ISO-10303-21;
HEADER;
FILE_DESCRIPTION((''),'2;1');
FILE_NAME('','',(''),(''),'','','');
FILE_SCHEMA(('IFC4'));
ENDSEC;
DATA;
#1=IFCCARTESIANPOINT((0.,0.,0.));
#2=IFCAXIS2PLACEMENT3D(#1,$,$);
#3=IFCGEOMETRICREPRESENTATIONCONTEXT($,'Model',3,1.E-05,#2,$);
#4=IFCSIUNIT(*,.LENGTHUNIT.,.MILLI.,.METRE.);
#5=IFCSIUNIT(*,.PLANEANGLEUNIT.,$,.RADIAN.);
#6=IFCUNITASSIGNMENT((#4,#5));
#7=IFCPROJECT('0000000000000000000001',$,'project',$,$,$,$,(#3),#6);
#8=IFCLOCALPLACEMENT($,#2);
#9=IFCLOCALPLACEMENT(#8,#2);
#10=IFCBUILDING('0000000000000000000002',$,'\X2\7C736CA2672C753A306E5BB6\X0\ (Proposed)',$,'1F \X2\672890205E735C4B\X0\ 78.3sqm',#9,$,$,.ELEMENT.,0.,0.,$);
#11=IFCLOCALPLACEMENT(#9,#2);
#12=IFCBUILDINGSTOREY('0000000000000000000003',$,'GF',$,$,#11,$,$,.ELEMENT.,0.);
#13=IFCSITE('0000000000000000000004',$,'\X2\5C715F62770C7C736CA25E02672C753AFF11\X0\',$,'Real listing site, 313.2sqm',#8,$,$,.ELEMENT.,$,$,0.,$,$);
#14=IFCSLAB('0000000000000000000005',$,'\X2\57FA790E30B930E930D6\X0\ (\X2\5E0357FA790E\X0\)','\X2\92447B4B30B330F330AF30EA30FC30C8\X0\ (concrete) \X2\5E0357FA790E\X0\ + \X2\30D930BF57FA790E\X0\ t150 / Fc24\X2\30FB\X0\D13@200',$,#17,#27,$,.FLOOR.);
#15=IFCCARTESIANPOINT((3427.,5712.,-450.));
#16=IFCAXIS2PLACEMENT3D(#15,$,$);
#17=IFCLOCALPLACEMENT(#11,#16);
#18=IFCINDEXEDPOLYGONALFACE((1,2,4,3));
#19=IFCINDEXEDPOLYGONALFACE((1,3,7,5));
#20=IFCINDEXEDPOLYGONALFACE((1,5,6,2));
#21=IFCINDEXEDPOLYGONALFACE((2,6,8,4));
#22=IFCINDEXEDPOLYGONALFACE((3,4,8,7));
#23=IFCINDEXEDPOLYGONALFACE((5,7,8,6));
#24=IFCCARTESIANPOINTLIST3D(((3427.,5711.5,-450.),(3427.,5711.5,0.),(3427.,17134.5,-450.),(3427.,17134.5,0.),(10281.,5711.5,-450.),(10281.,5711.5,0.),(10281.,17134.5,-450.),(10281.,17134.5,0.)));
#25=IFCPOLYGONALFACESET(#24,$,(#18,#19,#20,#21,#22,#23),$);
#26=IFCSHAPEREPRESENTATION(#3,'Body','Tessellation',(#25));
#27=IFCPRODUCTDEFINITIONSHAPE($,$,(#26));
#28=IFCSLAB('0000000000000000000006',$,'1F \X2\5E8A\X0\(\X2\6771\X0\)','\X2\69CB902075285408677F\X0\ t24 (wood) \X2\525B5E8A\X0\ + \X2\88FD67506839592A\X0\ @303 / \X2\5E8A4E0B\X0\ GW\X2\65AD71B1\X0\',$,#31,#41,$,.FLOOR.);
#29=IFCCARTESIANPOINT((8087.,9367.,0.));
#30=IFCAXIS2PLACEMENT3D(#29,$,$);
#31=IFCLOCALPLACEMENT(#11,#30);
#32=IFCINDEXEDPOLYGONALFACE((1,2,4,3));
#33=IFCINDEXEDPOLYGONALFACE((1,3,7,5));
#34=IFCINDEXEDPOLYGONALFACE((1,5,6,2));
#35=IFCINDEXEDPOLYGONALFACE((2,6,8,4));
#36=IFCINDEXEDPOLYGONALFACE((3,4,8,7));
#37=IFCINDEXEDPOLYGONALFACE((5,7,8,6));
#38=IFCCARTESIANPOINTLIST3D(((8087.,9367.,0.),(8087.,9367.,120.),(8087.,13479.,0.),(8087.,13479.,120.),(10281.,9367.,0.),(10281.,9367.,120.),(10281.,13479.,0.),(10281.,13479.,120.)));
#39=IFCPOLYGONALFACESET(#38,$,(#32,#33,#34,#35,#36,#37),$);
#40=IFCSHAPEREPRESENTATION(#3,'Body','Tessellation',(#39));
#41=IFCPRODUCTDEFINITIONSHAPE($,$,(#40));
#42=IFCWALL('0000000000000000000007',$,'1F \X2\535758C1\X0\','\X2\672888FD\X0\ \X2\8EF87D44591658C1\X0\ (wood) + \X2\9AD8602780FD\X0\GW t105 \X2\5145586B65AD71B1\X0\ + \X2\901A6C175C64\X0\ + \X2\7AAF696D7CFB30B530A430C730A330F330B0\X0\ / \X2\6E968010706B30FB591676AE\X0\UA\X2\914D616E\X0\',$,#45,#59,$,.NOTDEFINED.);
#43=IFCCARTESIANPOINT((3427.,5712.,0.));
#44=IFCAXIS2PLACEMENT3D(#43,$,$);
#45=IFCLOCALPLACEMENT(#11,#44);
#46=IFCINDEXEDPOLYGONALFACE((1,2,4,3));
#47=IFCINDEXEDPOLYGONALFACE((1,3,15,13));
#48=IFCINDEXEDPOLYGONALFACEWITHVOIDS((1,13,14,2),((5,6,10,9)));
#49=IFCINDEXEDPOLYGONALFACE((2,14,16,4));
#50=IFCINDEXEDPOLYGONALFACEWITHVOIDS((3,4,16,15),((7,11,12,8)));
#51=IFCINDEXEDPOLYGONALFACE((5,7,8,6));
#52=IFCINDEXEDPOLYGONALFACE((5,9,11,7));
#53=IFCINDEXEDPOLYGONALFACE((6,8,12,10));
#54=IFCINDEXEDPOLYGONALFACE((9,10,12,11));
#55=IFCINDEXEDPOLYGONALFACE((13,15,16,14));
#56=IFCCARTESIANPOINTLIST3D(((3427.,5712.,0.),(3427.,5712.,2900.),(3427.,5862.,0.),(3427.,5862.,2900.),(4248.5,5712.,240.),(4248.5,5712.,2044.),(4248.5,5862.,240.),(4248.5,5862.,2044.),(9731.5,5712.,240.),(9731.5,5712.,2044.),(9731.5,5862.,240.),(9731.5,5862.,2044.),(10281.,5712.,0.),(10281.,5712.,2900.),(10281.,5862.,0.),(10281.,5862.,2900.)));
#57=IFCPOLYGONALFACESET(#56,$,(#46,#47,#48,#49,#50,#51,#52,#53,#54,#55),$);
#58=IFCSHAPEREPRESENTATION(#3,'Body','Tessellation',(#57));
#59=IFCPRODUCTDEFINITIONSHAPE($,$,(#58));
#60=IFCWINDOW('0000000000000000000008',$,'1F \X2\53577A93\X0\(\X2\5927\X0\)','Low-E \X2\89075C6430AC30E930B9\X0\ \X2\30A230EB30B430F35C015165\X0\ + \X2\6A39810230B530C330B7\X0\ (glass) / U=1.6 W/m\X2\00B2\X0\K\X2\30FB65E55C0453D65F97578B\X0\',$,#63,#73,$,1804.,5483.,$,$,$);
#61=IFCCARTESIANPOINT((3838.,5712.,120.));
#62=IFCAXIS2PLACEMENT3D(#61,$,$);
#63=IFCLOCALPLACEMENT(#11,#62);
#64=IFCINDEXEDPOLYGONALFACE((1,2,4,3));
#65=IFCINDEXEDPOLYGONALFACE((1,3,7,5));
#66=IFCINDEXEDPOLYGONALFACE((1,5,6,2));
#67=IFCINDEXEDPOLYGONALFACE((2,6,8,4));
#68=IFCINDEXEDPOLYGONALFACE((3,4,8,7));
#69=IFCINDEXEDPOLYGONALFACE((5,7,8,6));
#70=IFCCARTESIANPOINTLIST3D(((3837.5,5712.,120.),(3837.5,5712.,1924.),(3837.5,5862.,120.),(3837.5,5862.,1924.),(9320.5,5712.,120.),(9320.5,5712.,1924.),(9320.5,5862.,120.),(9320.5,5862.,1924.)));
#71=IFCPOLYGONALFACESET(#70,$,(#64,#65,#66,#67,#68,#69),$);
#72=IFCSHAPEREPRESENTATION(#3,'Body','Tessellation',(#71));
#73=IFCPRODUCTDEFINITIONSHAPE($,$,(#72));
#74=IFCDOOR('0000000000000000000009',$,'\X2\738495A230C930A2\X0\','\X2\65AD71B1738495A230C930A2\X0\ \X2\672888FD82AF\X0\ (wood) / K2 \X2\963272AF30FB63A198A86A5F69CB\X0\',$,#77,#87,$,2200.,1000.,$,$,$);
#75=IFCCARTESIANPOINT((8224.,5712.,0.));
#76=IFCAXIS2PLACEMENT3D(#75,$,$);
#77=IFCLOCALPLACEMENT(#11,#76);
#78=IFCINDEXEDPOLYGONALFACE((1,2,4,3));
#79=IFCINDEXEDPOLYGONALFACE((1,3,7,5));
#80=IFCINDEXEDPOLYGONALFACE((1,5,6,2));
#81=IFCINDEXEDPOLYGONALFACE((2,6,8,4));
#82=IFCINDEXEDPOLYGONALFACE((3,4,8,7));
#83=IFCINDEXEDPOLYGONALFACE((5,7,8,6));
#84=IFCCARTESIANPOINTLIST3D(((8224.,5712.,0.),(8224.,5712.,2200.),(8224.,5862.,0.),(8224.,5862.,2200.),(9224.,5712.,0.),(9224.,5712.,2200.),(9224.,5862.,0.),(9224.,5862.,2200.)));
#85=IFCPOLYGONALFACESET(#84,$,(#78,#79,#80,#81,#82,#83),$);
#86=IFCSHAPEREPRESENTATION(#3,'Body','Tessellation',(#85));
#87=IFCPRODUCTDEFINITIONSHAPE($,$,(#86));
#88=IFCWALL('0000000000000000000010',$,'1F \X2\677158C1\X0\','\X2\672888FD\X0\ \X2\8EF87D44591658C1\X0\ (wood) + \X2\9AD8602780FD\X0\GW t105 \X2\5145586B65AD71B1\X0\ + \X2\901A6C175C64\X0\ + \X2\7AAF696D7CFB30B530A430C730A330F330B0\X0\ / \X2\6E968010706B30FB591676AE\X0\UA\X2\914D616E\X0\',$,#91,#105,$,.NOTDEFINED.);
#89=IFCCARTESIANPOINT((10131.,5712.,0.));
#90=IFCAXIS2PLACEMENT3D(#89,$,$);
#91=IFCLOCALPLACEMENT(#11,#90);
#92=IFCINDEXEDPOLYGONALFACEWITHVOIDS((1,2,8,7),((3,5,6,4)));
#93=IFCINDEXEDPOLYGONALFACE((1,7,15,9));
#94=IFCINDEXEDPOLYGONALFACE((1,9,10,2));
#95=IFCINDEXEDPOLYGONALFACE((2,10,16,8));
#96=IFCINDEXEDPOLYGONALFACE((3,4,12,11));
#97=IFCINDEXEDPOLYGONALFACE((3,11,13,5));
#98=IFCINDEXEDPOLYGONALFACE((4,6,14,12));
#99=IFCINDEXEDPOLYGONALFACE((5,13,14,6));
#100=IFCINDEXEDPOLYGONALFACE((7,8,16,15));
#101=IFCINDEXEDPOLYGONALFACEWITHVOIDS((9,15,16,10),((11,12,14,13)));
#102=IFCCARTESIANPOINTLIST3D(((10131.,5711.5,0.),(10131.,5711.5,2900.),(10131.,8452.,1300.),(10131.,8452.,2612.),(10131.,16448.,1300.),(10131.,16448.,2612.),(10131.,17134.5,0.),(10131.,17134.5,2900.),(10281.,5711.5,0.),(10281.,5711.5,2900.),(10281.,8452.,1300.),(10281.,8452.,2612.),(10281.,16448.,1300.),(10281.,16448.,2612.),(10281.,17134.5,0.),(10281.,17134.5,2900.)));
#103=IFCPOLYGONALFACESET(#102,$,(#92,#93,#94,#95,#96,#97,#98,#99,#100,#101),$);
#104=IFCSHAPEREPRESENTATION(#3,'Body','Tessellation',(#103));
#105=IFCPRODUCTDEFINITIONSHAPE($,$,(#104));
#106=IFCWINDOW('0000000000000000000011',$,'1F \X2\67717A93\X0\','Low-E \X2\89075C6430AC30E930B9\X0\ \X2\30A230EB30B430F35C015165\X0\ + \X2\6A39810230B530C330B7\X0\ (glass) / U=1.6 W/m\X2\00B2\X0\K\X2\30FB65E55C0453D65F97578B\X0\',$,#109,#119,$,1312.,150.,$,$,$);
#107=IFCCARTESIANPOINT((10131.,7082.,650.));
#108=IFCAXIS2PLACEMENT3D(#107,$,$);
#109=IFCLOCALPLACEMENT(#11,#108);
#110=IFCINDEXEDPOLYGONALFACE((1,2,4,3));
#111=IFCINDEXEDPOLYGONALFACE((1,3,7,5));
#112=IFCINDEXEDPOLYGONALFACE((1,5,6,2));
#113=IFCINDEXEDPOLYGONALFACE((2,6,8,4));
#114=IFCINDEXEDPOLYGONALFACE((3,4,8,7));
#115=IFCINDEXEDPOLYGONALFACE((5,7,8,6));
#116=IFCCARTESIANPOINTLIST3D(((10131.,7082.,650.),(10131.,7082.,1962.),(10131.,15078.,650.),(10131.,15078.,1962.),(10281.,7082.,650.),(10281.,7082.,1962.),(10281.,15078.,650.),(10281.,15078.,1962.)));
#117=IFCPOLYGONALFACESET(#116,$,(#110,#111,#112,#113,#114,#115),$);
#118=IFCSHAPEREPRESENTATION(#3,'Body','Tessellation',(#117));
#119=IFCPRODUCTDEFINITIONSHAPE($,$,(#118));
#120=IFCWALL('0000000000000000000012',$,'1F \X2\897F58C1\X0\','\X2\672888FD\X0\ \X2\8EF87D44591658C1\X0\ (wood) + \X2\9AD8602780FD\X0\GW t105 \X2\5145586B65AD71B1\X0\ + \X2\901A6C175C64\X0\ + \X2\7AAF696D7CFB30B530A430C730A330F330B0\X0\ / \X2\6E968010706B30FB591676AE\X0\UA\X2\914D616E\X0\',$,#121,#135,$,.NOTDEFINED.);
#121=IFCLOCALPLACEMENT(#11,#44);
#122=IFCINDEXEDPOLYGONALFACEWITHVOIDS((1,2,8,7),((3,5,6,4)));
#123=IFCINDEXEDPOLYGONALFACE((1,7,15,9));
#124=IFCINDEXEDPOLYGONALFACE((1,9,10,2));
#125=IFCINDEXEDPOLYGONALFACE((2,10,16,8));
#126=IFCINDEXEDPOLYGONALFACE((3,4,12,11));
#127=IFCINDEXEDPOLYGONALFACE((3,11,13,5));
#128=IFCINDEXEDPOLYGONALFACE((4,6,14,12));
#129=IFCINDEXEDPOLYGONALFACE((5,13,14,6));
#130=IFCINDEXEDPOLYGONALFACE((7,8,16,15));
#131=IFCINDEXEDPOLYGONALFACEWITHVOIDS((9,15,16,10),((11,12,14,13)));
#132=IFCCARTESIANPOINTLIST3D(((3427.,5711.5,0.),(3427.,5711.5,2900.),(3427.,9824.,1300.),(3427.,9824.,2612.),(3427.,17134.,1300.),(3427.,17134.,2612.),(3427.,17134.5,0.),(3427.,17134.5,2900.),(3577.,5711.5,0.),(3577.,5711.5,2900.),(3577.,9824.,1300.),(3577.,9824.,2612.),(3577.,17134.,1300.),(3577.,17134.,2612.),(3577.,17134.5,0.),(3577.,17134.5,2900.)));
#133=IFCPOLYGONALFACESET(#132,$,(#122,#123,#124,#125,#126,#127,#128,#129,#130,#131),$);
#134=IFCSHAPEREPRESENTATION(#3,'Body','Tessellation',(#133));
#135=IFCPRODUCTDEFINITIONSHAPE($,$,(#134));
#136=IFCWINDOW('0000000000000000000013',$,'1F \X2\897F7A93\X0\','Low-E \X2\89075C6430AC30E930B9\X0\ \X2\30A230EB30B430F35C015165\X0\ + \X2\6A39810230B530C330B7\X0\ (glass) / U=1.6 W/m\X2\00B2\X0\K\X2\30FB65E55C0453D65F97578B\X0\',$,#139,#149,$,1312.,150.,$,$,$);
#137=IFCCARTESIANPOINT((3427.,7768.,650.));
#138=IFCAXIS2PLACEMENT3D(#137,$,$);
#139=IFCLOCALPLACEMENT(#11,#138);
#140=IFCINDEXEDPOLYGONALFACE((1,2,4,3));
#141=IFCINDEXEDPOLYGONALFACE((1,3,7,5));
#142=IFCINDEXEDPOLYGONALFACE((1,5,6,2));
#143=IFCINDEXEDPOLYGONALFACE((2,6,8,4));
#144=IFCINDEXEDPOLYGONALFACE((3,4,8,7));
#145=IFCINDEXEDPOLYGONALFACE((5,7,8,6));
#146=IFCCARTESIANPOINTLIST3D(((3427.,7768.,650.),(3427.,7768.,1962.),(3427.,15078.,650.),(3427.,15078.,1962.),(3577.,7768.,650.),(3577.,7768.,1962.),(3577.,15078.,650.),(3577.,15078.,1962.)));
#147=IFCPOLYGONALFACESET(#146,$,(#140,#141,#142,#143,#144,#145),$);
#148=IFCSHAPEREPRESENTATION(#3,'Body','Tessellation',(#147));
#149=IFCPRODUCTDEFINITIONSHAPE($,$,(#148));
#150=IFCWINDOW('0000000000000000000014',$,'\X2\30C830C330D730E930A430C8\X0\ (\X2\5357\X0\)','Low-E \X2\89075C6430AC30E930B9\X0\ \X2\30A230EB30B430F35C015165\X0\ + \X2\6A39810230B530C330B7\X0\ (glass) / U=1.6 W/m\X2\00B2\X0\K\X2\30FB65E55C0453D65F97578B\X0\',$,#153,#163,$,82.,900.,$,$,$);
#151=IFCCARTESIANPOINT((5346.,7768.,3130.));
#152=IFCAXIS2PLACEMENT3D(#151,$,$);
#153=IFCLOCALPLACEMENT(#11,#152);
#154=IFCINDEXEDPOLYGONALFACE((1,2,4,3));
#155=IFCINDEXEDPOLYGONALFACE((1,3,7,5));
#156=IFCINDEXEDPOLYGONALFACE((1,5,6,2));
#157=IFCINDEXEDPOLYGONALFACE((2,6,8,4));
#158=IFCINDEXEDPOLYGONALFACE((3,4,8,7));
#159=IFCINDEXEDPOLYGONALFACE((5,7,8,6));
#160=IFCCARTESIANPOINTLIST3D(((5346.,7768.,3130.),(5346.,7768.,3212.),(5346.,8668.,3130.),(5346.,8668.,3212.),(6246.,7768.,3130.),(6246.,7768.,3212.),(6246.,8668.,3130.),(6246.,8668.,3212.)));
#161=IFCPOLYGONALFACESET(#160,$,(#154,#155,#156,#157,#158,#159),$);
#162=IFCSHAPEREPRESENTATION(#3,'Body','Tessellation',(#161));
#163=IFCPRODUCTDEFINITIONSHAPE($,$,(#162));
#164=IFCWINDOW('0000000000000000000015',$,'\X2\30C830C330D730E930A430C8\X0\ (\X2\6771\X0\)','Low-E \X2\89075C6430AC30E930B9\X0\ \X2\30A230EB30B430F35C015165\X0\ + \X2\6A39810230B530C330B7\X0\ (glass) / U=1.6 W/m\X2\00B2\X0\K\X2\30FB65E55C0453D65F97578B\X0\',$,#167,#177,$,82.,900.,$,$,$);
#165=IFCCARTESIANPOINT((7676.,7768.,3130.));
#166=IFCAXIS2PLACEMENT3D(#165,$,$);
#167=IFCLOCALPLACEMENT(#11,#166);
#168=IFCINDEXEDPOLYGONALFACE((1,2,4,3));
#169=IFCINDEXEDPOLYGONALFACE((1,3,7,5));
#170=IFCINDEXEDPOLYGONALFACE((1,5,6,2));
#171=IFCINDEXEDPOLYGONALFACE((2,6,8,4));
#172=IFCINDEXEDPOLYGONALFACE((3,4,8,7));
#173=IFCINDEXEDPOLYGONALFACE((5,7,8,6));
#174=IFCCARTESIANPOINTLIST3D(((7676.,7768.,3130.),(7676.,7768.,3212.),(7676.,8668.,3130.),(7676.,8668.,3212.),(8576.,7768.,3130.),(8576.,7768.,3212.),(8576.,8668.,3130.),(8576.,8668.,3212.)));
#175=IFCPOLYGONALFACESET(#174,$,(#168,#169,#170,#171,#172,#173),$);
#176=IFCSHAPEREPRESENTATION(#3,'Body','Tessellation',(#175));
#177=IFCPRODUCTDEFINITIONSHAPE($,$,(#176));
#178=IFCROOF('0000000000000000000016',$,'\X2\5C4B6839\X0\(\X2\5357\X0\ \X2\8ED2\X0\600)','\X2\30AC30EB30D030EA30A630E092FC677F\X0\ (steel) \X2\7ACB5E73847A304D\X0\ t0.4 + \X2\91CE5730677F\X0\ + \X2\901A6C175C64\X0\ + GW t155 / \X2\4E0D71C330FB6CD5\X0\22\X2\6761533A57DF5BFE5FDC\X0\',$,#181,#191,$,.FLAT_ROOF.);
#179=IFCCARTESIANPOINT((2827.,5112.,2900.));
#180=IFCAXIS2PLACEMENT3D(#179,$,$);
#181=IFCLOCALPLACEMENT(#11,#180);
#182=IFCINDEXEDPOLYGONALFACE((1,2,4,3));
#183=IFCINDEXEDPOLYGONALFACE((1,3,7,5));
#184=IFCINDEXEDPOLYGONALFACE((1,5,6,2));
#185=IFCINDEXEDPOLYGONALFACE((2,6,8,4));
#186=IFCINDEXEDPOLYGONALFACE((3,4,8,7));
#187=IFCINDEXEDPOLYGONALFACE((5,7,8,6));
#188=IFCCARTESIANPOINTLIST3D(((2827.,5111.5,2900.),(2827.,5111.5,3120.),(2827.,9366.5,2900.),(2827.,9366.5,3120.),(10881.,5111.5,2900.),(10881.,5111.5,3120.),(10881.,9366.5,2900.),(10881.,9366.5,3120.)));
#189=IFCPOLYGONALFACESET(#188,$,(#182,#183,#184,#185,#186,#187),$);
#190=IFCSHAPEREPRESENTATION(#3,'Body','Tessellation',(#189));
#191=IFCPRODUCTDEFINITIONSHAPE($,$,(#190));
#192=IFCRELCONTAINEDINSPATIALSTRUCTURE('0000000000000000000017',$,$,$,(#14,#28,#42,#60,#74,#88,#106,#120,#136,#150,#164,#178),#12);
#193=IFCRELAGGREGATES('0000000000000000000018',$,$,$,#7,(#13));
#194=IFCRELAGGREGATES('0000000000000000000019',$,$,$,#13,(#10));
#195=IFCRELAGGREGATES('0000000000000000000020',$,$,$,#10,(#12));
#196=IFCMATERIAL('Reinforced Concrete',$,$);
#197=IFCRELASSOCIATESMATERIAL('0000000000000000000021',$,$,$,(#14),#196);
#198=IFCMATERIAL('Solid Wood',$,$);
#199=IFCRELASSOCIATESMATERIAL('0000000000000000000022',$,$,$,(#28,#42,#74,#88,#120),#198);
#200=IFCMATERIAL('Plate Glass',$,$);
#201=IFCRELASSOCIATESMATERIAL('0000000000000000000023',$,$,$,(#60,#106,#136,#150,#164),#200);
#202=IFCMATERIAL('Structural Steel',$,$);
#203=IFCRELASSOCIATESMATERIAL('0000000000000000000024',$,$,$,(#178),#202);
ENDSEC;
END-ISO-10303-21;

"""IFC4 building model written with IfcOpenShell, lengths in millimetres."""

from ifc_helpers import new_model, si_unit, frame, frame_2d, origin, place, context, project, spatial, rectangle, extrude, material, element, fill, save


model = new_model("IFC4")

# Units and contexts
model_context = context("Model", 3, precision=1e-05, world=origin())
ifc_project = project(units=[si_unit("LENGTHUNIT", "METRE", prefix="MILLI"), si_unit("PLANEANGLEUNIT", "RADIAN")], contexts=[model_context])

# Site, building, storey
site_placement = place(None, origin())
site = spatial("IfcSite", under=ifc_project, at=site_placement, Name="山形県米沢市本町１", ObjectType="Real listing site, 313.2sqm", CompositionType="ELEMENT", RefElevation=0.0)
building_placement = place(site_placement, origin())
building = spatial("IfcBuilding", under=site, at=building_placement, Name="米沢本町の家 (Proposed)", ObjectType="1F 木造平屋 78.3sqm", CompositionType="ELEMENT", ElevationOfRefHeight=0.0, ElevationOfTerrain=0.0)
storey_placement = place(building_placement, origin())
storey = spatial("IfcBuildingStorey", under=building, at=storey_placement, Name="GF", CompositionType="ELEMENT", Elevation=0.0)

# Slabs
ifc_material_1 = material(Name="Reinforced Concrete")
slab_1_placement = place(storey_placement, frame((3427.0, 5712.0, -450.0)))
element("IfcSlab", 1, at=slab_1_placement, inside=storey, material=ifc_material_1, Name="基礎スラブ (布基礎)", Description="鉄筋コンクリート (concrete) 布基礎 + ベタ基礎 t150 / Fc24・D13@200", PredefinedType="FLOOR", context=model_context, shape_type="SweptSolid", body=[
    extrude(rectangle(XDim=6854.0, YDim=11423.0, at=frame_2d((3427.0, 5711.0))), frame((3427.0, 5712.0, -450.0)), (0.0, 0.0, 1.0), 450.0),
])
ifc_material_2 = material(Name="Solid Wood")
slab_2_placement = place(storey_placement, frame((8087.0, 9367.0, 0.0)))
element("IfcSlab", 2, at=slab_2_placement, inside=storey, material=ifc_material_2, Name="1F 床(東)", Description="構造用合板 t24 (wood) 剛床 + 製材根太 @303 / 床下 GW断熱", PredefinedType="FLOOR", context=model_context, shape_type="SweptSolid", body=[
    extrude(rectangle(XDim=2194.0, YDim=4112.0, at=frame_2d((1097.0, 2056.0))), frame((8087.0, 9367.0, 0.0)), (0.0, 0.0, 1.0), 120.0),
])

# Wall, openings, window, door
wall_1_placement = place(storey_placement, frame((3427.0, 5712.0, 0.0)))
wall_1 = element("IfcWall", 3, at=wall_1_placement, inside=storey, material=ifc_material_2, Name="1F 南壁", Description="木製 軸組外壁 (wood) + 高性能GW t105 充填断熱 + 通気層 + 窯業系サイディング / 準耐火・外皮UA配慮", PredefinedType="NOTDEFINED", context=model_context, shape_type="SweptSolid", body=[
    extrude(rectangle(XDim=6854.0, YDim=150.0, at=frame_2d((3427.0, 75.0))), frame((3427.0, 5712.0, 0.0)), (0.0, 0.0, 1.0), 2900.0),
])
opening_1_placement = place(storey_placement, frame((3838.0, 5712.0, 120.0)))
opening_1 = element("IfcOpeningElement", 4, at=opening_1_placement, cuts=wall_1, PredefinedType="NOTDEFINED", context=model_context, shape_type="SweptSolid", body=[
    extrude(rectangle(XDim=5483.0, YDim=150.0, at=frame_2d((2741.0, 75.0))), frame((3838.0, 5712.0, 120.0)), (0.0, 0.0, 1.0), 1804.0),
])
opening_2_placement = place(storey_placement, frame((8224.0, 5712.0, 0.0)))
opening_2 = element("IfcOpeningElement", 5, at=opening_2_placement, cuts=wall_1, PredefinedType="NOTDEFINED", context=model_context, shape_type="SweptSolid", body=[
    extrude(rectangle(XDim=1000.0, YDim=150.0, at=frame_2d((500.0, 75.0))), frame((8224.0, 5712.0, 0.0)), (0.0, 0.0, 1.0), 2200.0),
])
ifc_material_3 = material(Name="Plate Glass")
window_1_placement = place(storey_placement, frame((3838.0, 5712.0, 120.0)))
window_1 = element("IfcWindow", 6, at=window_1_placement, inside=storey, material=ifc_material_3, Name="1F 南窓(大)", Description="Low-E 複層ガラス アルゴン封入 + 樹脂サッシ (glass) / U=1.6 W/m²K・日射取得型", OverallHeight=1804.0, OverallWidth=5483.0, context=model_context, shape_type="SweptSolid", body=[
    extrude(rectangle(XDim=5483.0, YDim=150.0, at=frame_2d((2741.0, 75.0))), frame((3838.0, 5712.0, 120.0)), (0.0, 0.0, 1.0), 1804.0),
])
fill(opening_1, window_1)
door_placement = place(storey_placement, frame((8224.0, 5712.0, 0.0)))
door = element("IfcDoor", 7, at=door_placement, inside=storey, material=ifc_material_2, Name="玄関ドア", Description="断熱玄関ドア 木製芯 (wood) / K2 防犯・採風機構", OverallHeight=2200.0, OverallWidth=1000.0, context=model_context, shape_type="SweptSolid", body=[
    extrude(rectangle(XDim=1000.0, YDim=150.0, at=frame_2d((500.0, 75.0))), frame((8224.0, 5712.0, 0.0)), (0.0, 0.0, 1.0), 2200.0),
])
fill(opening_2, door)

# Walls, openings, windows
wall_2_placement = place(storey_placement, frame((10131.0, 5712.0, 0.0)))
wall_2 = element("IfcWall", 8, at=wall_2_placement, inside=storey, material=ifc_material_2, Name="1F 東壁", Description="木製 軸組外壁 (wood) + 高性能GW t105 充填断熱 + 通気層 + 窯業系サイディング / 準耐火・外皮UA配慮", PredefinedType="NOTDEFINED", context=model_context, shape_type="SweptSolid", body=[
    extrude(rectangle(XDim=150.0, YDim=11423.0, at=frame_2d((75.0, 5711.0))), frame((10131.0, 5712.0, 0.0)), (0.0, 0.0, 1.0), 2900.0),
])
opening_3_placement = place(storey_placement, frame((10131.0, 7082.0, 650.0)))
opening_3 = element("IfcOpeningElement", 9, at=opening_3_placement, cuts=wall_2, PredefinedType="NOTDEFINED", context=model_context, shape_type="SweptSolid", body=[
    extrude(rectangle(XDim=150.0, YDim=7996.0, at=frame_2d((75.0, 3998.0))), frame((10131.0, 7082.0, 650.0)), (0.0, 0.0, 1.0), 1312.0),
])
window_2_placement = place(storey_placement, frame((10131.0, 7082.0, 650.0)))
window_2 = element("IfcWindow", 10, at=window_2_placement, inside=storey, material=ifc_material_3, Name="1F 東窓", Description="Low-E 複層ガラス アルゴン封入 + 樹脂サッシ (glass) / U=1.6 W/m²K・日射取得型", OverallHeight=1312.0, OverallWidth=150.0, context=model_context, shape_type="SweptSolid", body=[
    extrude(rectangle(XDim=150.0, YDim=7996.0, at=frame_2d((75.0, 3998.0))), frame((10131.0, 7082.0, 650.0)), (0.0, 0.0, 1.0), 1312.0),
])
fill(opening_3, window_2)
wall_3_placement = place(storey_placement, frame((3427.0, 5712.0, 0.0)))
wall_3 = element("IfcWall", 11, at=wall_3_placement, inside=storey, material=ifc_material_2, Name="1F 西壁", Description="木製 軸組外壁 (wood) + 高性能GW t105 充填断熱 + 通気層 + 窯業系サイディング / 準耐火・外皮UA配慮", PredefinedType="NOTDEFINED", context=model_context, shape_type="SweptSolid", body=[
    extrude(rectangle(XDim=150.0, YDim=11423.0, at=frame_2d((75.0, 5711.0))), frame((3427.0, 5712.0, 0.0)), (0.0, 0.0, 1.0), 2900.0),
])
opening_4_placement = place(storey_placement, frame((3427.0, 7768.0, 650.0)))
opening_4 = element("IfcOpeningElement", 12, at=opening_4_placement, cuts=wall_3, PredefinedType="NOTDEFINED", context=model_context, shape_type="SweptSolid", body=[
    extrude(rectangle(XDim=150.0, YDim=7310.0, at=frame_2d((75.0, 3655.0))), frame((3427.0, 7768.0, 650.0)), (0.0, 0.0, 1.0), 1312.0),
])
window_3_placement = place(storey_placement, frame((3427.0, 7768.0, 650.0)))
window_3 = element("IfcWindow", 13, at=window_3_placement, inside=storey, material=ifc_material_3, Name="1F 西窓", Description="Low-E 複層ガラス アルゴン封入 + 樹脂サッシ (glass) / U=1.6 W/m²K・日射取得型", OverallHeight=1312.0, OverallWidth=150.0, context=model_context, shape_type="SweptSolid", body=[
    extrude(rectangle(XDim=150.0, YDim=7310.0, at=frame_2d((75.0, 3655.0))), frame((3427.0, 7768.0, 650.0)), (0.0, 0.0, 1.0), 1312.0),
])
fill(opening_4, window_3)

# Windows
window_4_placement = place(storey_placement, frame((5346.0, 7768.0, 3130.0)))
element("IfcWindow", 14, at=window_4_placement, inside=storey, material=ifc_material_3, Name="トップライト (南)", Description="Low-E 複層ガラス アルゴン封入 + 樹脂サッシ (glass) / U=1.6 W/m²K・日射取得型", OverallHeight=82.0, OverallWidth=900.0, context=model_context, shape_type="SweptSolid", body=[
    extrude(rectangle(XDim=900.0, YDim=900.0, at=frame_2d((450.0, 450.0))), frame((5346.0, 7768.0, 3130.0)), (0.0, 0.0, 1.0), 82.0),
])
window_5_placement = place(storey_placement, frame((7676.0, 7768.0, 3130.0)))
element("IfcWindow", 15, at=window_5_placement, inside=storey, material=ifc_material_3, Name="トップライト (東)", Description="Low-E 複層ガラス アルゴン封入 + 樹脂サッシ (glass) / U=1.6 W/m²K・日射取得型", OverallHeight=82.0, OverallWidth=900.0, context=model_context, shape_type="SweptSolid", body=[
    extrude(rectangle(XDim=900.0, YDim=900.0, at=frame_2d((450.0, 450.0))), frame((7676.0, 7768.0, 3130.0)), (0.0, 0.0, 1.0), 82.0),
])

# Roof
ifc_material_4 = material(Name="Structural Steel")
roof_placement = place(storey_placement, frame((2827.0, 5112.0, 2900.0)))
element("IfcRoof", 16, at=roof_placement, inside=storey, material=ifc_material_4, Name="屋根(南 軒600)", Description="ガルバリウム鋼板 (steel) 立平葺き t0.4 + 野地板 + 通気層 + GW t155 / 不燃・法22条区域対応", PredefinedType="FLAT_ROOF", context=model_context, shape_type="SweptSolid", body=[
    extrude(rectangle(XDim=8054.0, YDim=4255.0, at=frame_2d((4027.0, 2127.0))), frame((2827.0, 5112.0, 2900.0)), (0.0, 0.0, 1.0), 220.0),
])

save(model, "model.ifc")
